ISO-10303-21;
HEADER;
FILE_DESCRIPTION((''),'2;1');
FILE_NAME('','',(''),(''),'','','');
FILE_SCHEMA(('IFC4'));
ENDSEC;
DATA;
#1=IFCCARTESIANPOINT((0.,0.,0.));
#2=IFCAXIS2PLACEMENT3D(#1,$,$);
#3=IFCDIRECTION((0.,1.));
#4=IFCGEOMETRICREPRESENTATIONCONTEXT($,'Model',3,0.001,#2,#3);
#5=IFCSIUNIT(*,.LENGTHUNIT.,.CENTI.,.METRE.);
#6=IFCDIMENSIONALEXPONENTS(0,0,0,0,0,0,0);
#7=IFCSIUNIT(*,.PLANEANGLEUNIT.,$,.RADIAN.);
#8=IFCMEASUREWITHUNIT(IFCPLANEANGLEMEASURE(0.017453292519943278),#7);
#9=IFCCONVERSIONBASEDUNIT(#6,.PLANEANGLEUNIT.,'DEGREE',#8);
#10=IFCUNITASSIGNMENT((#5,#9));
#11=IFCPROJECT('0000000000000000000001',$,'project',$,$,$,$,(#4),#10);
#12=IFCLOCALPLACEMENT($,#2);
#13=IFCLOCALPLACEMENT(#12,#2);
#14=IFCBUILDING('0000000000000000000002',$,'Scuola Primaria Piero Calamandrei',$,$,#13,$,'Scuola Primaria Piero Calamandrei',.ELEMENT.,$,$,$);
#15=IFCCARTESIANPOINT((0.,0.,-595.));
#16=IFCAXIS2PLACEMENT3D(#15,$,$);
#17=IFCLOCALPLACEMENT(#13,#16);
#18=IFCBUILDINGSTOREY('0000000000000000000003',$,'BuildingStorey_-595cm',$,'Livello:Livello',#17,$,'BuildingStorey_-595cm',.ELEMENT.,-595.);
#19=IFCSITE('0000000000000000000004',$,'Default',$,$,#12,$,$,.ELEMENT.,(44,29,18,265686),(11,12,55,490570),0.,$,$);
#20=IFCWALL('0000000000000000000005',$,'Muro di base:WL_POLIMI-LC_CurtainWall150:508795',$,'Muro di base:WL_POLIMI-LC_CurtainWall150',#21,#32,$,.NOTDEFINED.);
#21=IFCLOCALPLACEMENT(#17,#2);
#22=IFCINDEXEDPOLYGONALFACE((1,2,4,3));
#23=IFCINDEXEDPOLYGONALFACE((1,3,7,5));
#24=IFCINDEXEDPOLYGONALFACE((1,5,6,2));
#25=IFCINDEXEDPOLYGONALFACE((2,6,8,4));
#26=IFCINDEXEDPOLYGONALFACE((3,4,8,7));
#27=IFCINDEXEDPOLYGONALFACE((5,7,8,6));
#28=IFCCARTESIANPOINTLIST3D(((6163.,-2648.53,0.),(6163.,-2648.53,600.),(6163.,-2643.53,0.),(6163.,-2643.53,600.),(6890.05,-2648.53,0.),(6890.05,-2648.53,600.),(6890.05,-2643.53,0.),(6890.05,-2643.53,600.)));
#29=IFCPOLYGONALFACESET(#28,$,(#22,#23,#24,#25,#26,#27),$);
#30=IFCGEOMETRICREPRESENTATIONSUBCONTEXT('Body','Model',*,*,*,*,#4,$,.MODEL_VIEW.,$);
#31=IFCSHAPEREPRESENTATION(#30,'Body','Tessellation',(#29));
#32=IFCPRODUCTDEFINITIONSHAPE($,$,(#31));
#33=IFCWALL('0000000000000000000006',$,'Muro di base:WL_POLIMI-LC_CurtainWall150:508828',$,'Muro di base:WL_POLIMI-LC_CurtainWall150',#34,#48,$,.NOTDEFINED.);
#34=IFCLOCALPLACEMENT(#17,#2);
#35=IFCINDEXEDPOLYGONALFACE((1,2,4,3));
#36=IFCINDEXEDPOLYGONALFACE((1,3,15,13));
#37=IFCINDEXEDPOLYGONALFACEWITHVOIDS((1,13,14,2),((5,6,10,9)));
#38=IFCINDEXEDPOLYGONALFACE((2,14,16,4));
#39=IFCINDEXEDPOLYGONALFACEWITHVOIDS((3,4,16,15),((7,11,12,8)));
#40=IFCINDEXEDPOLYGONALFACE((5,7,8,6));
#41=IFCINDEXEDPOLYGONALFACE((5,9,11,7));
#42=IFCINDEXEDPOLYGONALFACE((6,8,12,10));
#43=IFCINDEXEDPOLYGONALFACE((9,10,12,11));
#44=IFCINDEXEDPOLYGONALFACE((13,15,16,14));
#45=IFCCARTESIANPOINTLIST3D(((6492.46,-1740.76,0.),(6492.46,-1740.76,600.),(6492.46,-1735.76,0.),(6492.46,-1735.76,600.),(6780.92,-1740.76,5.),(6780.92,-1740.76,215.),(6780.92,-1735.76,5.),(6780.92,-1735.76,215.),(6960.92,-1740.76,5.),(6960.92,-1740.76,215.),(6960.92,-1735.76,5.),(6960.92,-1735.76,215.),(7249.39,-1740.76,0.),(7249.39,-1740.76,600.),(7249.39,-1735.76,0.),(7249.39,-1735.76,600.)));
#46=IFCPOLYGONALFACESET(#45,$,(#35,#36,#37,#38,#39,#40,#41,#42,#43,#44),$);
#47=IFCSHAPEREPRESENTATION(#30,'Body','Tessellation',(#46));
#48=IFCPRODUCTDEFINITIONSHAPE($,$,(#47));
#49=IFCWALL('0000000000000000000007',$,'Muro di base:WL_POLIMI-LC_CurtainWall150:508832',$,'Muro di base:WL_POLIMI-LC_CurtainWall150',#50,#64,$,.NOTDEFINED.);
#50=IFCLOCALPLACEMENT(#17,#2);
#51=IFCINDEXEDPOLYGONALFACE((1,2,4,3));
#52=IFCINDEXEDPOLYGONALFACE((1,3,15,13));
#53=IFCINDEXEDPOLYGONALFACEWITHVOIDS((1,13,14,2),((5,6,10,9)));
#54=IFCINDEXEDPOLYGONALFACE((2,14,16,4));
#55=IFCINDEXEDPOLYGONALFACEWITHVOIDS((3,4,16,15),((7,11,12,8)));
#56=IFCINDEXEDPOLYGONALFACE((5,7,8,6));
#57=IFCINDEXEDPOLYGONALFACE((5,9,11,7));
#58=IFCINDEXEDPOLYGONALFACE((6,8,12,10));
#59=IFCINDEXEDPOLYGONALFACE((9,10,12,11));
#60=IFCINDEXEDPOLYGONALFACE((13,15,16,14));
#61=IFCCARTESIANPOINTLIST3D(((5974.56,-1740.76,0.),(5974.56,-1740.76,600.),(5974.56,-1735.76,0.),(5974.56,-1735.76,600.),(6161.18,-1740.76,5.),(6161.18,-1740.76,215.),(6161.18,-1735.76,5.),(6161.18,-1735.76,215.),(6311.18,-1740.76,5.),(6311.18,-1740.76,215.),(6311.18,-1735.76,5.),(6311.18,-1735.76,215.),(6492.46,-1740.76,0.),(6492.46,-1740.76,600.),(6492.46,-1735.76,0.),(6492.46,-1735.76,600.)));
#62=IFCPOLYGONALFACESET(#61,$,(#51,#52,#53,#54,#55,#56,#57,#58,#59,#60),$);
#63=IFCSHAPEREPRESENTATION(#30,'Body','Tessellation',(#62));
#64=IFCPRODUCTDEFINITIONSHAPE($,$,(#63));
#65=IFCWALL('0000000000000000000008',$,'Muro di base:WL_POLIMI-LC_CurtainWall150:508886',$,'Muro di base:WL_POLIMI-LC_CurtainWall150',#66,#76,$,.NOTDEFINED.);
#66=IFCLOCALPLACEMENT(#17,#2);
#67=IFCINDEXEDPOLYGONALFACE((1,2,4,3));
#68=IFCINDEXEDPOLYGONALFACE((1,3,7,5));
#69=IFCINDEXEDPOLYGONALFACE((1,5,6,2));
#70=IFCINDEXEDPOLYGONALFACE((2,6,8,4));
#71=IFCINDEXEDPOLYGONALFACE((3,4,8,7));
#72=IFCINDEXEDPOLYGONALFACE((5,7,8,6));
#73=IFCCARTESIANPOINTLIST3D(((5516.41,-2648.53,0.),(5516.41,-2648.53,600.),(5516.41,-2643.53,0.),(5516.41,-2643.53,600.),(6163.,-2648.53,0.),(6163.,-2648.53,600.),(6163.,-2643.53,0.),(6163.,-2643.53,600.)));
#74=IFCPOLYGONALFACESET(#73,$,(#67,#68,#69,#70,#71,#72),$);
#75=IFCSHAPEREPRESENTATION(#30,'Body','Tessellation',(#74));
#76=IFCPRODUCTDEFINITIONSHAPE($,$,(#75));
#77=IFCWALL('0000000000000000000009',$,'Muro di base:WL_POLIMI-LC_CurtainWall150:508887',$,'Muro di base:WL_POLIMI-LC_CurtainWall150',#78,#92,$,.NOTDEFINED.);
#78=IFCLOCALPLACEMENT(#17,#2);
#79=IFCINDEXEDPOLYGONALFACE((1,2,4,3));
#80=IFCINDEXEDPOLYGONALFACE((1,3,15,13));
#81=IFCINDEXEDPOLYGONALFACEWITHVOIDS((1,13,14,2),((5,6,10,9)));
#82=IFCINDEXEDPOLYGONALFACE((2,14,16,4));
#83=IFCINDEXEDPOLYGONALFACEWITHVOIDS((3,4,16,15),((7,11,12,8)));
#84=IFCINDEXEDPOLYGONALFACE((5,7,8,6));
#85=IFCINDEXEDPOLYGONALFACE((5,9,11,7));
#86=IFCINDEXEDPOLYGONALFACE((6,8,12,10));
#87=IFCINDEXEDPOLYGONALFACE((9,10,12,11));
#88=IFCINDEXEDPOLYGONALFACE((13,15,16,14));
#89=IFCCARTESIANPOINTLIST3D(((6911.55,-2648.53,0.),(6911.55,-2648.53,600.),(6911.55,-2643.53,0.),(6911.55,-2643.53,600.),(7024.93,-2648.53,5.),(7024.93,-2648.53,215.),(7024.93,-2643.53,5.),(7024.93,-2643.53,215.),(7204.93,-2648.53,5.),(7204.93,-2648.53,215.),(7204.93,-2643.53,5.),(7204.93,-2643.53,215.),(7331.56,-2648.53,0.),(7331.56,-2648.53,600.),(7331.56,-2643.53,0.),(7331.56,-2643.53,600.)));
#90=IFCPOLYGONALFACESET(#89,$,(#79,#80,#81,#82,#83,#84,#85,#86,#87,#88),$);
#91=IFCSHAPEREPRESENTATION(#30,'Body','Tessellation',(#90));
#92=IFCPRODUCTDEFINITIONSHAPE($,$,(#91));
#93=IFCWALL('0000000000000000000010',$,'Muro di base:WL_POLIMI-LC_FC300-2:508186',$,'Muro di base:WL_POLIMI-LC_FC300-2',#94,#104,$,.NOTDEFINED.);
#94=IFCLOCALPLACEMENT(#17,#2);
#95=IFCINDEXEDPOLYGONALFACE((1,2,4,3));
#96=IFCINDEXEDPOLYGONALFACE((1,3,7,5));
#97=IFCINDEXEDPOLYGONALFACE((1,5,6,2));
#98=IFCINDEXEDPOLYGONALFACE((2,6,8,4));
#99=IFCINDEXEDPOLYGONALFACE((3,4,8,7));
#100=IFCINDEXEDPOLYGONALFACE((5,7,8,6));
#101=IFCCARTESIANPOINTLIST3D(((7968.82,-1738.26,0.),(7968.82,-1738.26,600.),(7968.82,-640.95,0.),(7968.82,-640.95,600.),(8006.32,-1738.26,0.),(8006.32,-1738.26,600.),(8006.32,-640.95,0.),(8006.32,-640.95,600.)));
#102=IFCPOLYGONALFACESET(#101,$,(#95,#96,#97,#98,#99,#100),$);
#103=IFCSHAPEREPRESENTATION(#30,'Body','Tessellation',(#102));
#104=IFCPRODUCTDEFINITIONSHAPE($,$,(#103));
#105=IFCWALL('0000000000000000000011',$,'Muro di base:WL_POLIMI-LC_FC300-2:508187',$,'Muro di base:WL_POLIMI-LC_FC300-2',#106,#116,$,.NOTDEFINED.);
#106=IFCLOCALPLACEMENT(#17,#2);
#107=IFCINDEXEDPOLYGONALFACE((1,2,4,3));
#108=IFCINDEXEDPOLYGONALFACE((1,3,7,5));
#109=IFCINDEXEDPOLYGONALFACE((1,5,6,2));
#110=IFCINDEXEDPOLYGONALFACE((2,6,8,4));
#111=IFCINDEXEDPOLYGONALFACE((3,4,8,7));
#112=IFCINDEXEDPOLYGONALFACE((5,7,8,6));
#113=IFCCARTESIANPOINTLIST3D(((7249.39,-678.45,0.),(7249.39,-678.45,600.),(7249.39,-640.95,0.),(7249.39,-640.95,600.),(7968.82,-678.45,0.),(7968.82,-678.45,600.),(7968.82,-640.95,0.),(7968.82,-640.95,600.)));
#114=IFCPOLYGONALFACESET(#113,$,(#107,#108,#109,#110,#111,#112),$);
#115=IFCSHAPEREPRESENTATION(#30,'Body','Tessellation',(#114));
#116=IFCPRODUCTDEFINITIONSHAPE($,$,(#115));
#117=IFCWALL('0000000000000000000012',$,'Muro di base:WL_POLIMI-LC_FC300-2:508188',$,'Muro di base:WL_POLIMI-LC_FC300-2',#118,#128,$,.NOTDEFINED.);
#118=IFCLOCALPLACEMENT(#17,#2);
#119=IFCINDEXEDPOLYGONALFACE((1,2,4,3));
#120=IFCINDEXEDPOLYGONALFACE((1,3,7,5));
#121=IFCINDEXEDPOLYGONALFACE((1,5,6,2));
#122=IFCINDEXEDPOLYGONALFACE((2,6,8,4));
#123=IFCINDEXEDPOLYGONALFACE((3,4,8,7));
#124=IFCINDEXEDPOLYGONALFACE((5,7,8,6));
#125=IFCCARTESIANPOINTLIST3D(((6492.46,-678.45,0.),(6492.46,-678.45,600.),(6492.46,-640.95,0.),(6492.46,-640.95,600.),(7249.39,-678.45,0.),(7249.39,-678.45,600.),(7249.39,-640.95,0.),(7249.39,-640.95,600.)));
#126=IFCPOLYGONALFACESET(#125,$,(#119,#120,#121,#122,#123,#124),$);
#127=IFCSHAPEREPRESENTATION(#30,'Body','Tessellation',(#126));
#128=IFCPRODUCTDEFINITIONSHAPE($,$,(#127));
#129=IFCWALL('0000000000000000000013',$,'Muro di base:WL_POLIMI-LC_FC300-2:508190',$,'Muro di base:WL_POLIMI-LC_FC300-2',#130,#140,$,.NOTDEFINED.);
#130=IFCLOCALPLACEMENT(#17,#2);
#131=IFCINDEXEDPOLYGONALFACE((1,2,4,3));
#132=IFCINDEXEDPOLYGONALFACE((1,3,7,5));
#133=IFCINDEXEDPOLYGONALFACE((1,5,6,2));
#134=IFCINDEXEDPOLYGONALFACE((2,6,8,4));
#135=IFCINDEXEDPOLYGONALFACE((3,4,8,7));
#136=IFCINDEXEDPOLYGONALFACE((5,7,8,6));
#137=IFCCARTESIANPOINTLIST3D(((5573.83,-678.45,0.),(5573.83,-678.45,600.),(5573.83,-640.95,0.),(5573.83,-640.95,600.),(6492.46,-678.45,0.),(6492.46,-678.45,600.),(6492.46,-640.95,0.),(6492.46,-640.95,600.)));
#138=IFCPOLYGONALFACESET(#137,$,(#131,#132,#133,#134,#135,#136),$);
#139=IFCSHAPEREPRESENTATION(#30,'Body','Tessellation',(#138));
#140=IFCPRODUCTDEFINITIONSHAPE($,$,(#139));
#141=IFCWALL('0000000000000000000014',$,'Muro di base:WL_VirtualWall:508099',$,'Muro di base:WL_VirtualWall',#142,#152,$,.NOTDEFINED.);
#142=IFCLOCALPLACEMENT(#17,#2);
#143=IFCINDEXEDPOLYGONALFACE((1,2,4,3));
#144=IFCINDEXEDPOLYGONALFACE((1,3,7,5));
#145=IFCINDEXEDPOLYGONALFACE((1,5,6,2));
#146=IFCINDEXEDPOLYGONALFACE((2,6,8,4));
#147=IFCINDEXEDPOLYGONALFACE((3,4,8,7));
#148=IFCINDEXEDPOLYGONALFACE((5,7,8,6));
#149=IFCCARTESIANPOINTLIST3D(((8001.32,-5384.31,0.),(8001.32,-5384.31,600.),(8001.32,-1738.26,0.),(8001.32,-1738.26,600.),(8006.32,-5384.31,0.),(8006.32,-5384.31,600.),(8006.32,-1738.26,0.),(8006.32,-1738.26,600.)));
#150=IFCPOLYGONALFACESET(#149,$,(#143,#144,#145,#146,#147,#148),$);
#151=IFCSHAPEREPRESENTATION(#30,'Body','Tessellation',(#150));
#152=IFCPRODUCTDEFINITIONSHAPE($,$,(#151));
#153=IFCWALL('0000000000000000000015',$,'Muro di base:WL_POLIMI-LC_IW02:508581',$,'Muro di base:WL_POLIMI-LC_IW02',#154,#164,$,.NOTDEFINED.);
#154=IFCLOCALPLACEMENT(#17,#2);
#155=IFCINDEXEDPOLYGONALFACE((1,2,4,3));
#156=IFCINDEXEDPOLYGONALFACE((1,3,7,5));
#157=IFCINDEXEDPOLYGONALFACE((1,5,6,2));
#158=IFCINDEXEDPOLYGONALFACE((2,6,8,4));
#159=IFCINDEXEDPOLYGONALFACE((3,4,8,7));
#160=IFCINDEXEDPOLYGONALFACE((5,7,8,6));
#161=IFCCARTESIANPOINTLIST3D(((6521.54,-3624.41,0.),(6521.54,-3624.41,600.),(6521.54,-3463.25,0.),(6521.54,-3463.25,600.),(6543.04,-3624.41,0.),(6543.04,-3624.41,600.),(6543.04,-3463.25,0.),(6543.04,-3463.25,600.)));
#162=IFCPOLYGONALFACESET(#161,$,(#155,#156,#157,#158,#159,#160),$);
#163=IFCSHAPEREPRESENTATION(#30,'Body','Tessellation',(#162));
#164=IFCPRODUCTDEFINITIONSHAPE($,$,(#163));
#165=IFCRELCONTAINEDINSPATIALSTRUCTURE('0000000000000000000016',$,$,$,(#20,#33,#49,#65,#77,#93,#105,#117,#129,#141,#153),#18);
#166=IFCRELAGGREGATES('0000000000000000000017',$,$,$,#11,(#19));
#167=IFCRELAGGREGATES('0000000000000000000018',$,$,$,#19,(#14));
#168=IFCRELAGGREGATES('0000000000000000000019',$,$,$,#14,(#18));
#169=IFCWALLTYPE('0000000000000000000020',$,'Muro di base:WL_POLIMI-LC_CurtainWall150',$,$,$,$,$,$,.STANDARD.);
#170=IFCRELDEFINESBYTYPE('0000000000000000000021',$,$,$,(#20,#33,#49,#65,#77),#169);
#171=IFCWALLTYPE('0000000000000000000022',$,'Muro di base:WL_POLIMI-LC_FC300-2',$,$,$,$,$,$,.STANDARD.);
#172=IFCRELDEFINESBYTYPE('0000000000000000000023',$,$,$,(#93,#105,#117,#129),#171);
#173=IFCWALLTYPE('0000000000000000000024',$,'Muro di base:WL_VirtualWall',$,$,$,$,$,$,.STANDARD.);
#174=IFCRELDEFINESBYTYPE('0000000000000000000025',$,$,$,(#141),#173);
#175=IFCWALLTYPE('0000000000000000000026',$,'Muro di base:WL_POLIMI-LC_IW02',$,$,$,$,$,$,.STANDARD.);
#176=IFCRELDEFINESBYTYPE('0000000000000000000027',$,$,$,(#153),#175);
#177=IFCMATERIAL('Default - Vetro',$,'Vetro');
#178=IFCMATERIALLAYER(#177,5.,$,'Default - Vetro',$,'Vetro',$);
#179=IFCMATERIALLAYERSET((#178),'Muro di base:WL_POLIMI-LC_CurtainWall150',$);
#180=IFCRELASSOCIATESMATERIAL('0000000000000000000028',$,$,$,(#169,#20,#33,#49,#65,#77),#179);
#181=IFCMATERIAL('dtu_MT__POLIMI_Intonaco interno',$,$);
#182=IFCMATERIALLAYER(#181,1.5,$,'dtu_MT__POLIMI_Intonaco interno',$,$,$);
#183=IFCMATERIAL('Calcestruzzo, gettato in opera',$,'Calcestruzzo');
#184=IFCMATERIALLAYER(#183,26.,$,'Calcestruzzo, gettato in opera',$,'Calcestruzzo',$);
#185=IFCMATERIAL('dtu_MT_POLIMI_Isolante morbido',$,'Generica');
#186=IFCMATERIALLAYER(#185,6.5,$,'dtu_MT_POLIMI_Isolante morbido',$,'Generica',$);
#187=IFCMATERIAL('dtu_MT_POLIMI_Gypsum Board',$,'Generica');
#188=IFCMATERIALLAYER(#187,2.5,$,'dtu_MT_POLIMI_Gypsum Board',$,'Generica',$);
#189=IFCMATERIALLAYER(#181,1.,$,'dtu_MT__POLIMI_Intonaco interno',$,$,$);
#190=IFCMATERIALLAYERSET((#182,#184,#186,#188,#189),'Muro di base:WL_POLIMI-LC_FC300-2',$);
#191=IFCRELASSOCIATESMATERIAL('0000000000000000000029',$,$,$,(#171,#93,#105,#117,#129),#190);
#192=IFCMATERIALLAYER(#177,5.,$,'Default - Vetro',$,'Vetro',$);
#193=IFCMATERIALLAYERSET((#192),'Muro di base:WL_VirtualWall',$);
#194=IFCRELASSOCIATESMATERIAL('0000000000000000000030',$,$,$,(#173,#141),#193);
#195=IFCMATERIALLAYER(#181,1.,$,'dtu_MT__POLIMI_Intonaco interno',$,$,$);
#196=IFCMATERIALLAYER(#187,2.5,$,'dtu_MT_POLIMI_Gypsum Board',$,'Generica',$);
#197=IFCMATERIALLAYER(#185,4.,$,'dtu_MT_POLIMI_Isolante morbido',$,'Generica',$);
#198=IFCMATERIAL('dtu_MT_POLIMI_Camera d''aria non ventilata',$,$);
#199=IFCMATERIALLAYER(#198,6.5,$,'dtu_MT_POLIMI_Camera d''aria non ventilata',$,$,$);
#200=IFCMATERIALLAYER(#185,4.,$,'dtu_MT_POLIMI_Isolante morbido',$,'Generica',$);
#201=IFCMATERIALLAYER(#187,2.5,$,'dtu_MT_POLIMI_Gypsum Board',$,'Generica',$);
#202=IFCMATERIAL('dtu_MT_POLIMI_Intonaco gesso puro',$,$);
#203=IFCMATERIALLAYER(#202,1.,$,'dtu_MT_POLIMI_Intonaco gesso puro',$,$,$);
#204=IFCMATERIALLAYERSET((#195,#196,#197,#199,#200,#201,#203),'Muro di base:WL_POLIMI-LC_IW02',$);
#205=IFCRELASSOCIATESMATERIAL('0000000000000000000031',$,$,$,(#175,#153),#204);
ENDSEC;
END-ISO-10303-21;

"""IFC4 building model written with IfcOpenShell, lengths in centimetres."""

from ifc_helpers import new_model, entity, si_unit, converted_unit, direction, frame, frame_2d, origin, place, context, subcontext, project, spatial, rectangle, extrude, material, layer, layer_set, layer_usage, type_object, element, save


model = new_model("IFC4")

# Units and contexts
model_context = context("Model", 3, precision=0.001, world=origin(), true_north=direction((0.0, 1.0)))
body_context = subcontext(model_context, "Body", "Model", "MODEL_VIEW")
ifc_project = project(units=[si_unit("LENGTHUNIT", "METRE", prefix="CENTI"), converted_unit("PLANEANGLEUNIT", "DEGREE", entity("IfcPlaneAngleMeasure", 0.017453292519943278), si_unit("PLANEANGLEUNIT", "RADIAN"), dimensions=[0, 0, 0, 0, 0, 0, 0])], contexts=[model_context])

# Site, building, storey
site_placement = place(None, origin())
site = spatial("IfcSite", under=ifc_project, at=site_placement, Name="Default", CompositionType="ELEMENT", RefLatitude=(44, 29, 18, 265686), RefLongitude=(11, 12, 55, 490570), RefElevation=0.0)
building_placement = place(site_placement, origin())
building = spatial("IfcBuilding", under=site, at=building_placement, Name="Scuola Primaria Piero Calamandrei", LongName="Scuola Primaria Piero Calamandrei", CompositionType="ELEMENT")
storey_placement = place(building_placement, frame((0.0, 0.0, -595.0)))
storey = spatial("IfcBuildingStorey", under=building, at=storey_placement, Name="BuildingStorey_-595cm", ObjectType="Livello:Livello", LongName="BuildingStorey_-595cm", CompositionType="ELEMENT", Elevation=-595.0)

# Wall
ifc_material_1 = material(Name="Default - Vetro", Category="Vetro")
ifc_layer_1 = layer(ifc_material_1, 5.0, Name="Default - Vetro", Category="Vetro")
ifc_layer_set_1 = layer_set([ifc_layer_1], Name="Muro di base:WL_POLIMI-LC_CurtainWall150")
ifc_layer_usage_1 = layer_usage(ifc_layer_set_1, "AXIS2", "NEGATIVE", 2.5)
wall_type_1 = type_object("IfcWallType", Name="Muro di base:WL_POLIMI-LC_CurtainWall150", PredefinedType="STANDARD", material=ifc_layer_set_1)
wall_1_placement = place(storey_placement, frame((6163.0, -2646.03, 0.0)))
element("IfcWall", 1, at=wall_1_placement, inside=storey, type_object=wall_type_1, material=ifc_layer_usage_1, Name="Muro di base:WL_POLIMI-LC_CurtainWall150:508795", ObjectType="Muro di base:WL_POLIMI-LC_CurtainWall150", PredefinedType="NOTDEFINED", context=body_context, shape_type="SweptSolid", body=[
    extrude(rectangle(XDim=727.05, YDim=5.0, at=frame_2d((363.53, 0.0), x_axis=(-1.0, 0.0))), origin(), (0.0, 0.0, 1.0), 600.0),
])

# Walls, openings
ifc_layer_usage_2 = layer_usage(ifc_layer_set_1, "AXIS2", "NEGATIVE", 2.5)
wall_2_placement = place(storey_placement, frame((6492.46, -1738.26, 0.0)))
wall_2 = element("IfcWall", 2, at=wall_2_placement, inside=storey, type_object=wall_type_1, material=ifc_layer_usage_2, Name="Muro di base:WL_POLIMI-LC_CurtainWall150:508828", ObjectType="Muro di base:WL_POLIMI-LC_CurtainWall150", PredefinedType="NOTDEFINED", context=body_context, shape_type="SweptSolid", body=[
    extrude(rectangle(XDim=756.93, YDim=5.0, at=frame_2d((378.47, 0.0), x_axis=(-1.0, 0.0))), origin(), (0.0, 0.0, 1.0), 600.0),
])
opening_1_placement = place(wall_2_placement, frame((468.47, 2.5, 5.0)))
element("IfcOpeningElement", 3, at=opening_1_placement, cuts=wall_2, PredefinedType="OPENING", context=body_context, shape_type="SweptSolid", body=[
    extrude(rectangle(XDim=210.0, YDim=180.0, at=frame_2d((105.0, 90.0), x_axis=(-1.0, 0.0))), frame((0.0, 0.0, 0.0), z_axis=(0.0, -1.0, 0.0), x_axis=(0.0, 0.0, 1.0)), (0.0, 0.0, 1.0), 5.0),
])
ifc_layer_usage_3 = layer_usage(ifc_layer_set_1, "AXIS2", "NEGATIVE", 2.5)
wall_3_placement = place(storey_placement, frame((5974.56, -1738.26, 0.0)))
wall_3 = element("IfcWall", 4, at=wall_3_placement, inside=storey, type_object=wall_type_1, material=ifc_layer_usage_3, Name="Muro di base:WL_POLIMI-LC_CurtainWall150:508832", ObjectType="Muro di base:WL_POLIMI-LC_CurtainWall150", PredefinedType="NOTDEFINED", context=body_context, shape_type="SweptSolid", body=[
    extrude(rectangle(XDim=517.9, YDim=5.0, at=frame_2d((258.95, 0.0), x_axis=(-1.0, 0.0))), origin(), (0.0, 0.0, 1.0), 600.0),
])
opening_2_placement = place(wall_3_placement, frame((336.63, 2.5, 5.0)))
element("IfcOpeningElement", 5, at=opening_2_placement, cuts=wall_3, PredefinedType="OPENING", context=body_context, shape_type="SweptSolid", body=[
    extrude(rectangle(XDim=210.0, YDim=150.0, at=frame_2d((105.0, 75.0), x_axis=(-1.0, 0.0))), frame((0.0, 0.0, 0.0), z_axis=(0.0, -1.0, 0.0), x_axis=(0.0, 0.0, 1.0)), (0.0, 0.0, 1.0), 5.0),
])

# Wall
ifc_layer_usage_4 = layer_usage(ifc_layer_set_1, "AXIS2", "NEGATIVE", 2.5)
wall_4_placement = place(storey_placement, frame((6163.0, -2646.03, 0.0), z_axis=(0.0, 0.0, 1.0), x_axis=(-1.0, 0.0, 0.0)))
element("IfcWall", 6, at=wall_4_placement, inside=storey, type_object=wall_type_1, material=ifc_layer_usage_4, Name="Muro di base:WL_POLIMI-LC_CurtainWall150:508886", ObjectType="Muro di base:WL_POLIMI-LC_CurtainWall150", PredefinedType="NOTDEFINED", context=body_context, shape_type="SweptSolid", body=[
    extrude(rectangle(XDim=646.58, YDim=5.0, at=frame_2d((323.29, 0.0), x_axis=(-1.0, 0.0))), origin(), (0.0, 0.0, 1.0), 600.0),
])

# Wall, opening
ifc_layer_usage_5 = layer_usage(ifc_layer_set_1, "AXIS2", "NEGATIVE", 2.5)
wall_5_placement = place(storey_placement, frame((7331.56, -2646.03, 0.0), z_axis=(0.0, 0.0, 1.0), x_axis=(-1.0, 0.0, 0.0)))
wall_5 = element("IfcWall", 7, at=wall_5_placement, inside=storey, type_object=wall_type_1, material=ifc_layer_usage_5, Name="Muro di base:WL_POLIMI-LC_CurtainWall150:508887", ObjectType="Muro di base:WL_POLIMI-LC_CurtainWall150", PredefinedType="NOTDEFINED", context=body_context, shape_type="SweptSolid", body=[
    extrude(rectangle(XDim=420.01, YDim=5.0, at=frame_2d((210.01, 0.0), x_axis=(-1.0, 0.0))), origin(), (0.0, 0.0, 1.0), 600.0),
])
opening_3_placement = place(wall_5_placement, frame((126.63, -2.5, 5.0)))
element("IfcOpeningElement", 8, at=opening_3_placement, cuts=wall_5, PredefinedType="OPENING", context=body_context, shape_type="SweptSolid", body=[
    extrude(rectangle(XDim=210.0, YDim=180.0, at=frame_2d((105.0, 90.0), x_axis=(1.0, 0.0))), frame((0.0, 0.0, 0.0), z_axis=(0.0, 1.0, 0.0), x_axis=(0.0, 0.0, 1.0)), (0.0, 0.0, 1.0), 5.0),
])

# Walls
ifc_material_2 = material(Name="dtu_MT__POLIMI_Intonaco interno")
ifc_layer_2 = layer(ifc_material_2, 1.5, Name="dtu_MT__POLIMI_Intonaco interno")
ifc_material_3 = material(Name="Calcestruzzo, gettato in opera", Category="Calcestruzzo")
ifc_layer_3 = layer(ifc_material_3, 26.0, Name="Calcestruzzo, gettato in opera", Category="Calcestruzzo")
ifc_material_4 = material(Name="dtu_MT_POLIMI_Isolante morbido", Category="Generica")
ifc_layer_4 = layer(ifc_material_4, 6.5, Name="dtu_MT_POLIMI_Isolante morbido", Category="Generica")
ifc_material_5 = material(Name="dtu_MT_POLIMI_Gypsum Board", Category="Generica")
ifc_layer_5 = layer(ifc_material_5, 2.5, Name="dtu_MT_POLIMI_Gypsum Board", Category="Generica")
ifc_layer_6 = layer(ifc_material_2, 1.0, Name="dtu_MT__POLIMI_Intonaco interno")
ifc_layer_set_2 = layer_set([ifc_layer_2, ifc_layer_3, ifc_layer_4, ifc_layer_5, ifc_layer_6], Name="Muro di base:WL_POLIMI-LC_FC300-2")
ifc_layer_usage_6 = layer_usage(ifc_layer_set_2, "AXIS2", "NEGATIVE", 18.75)
wall_type_2 = type_object("IfcWallType", Name="Muro di base:WL_POLIMI-LC_FC300-2", PredefinedType="STANDARD", material=ifc_layer_set_2)
wall_6_placement = place(storey_placement, frame((7987.57, -640.95, 0.0), z_axis=(0.0, 0.0, 1.0), x_axis=(0.0, -1.0, 0.0)))
element("IfcWall", 9, at=wall_6_placement, inside=storey, type_object=wall_type_2, material=ifc_layer_usage_6, Name="Muro di base:WL_POLIMI-LC_FC300-2:508186", ObjectType="Muro di base:WL_POLIMI-LC_FC300-2", PredefinedType="NOTDEFINED", context=body_context, shape_type="SweptSolid", body=[
    extrude(rectangle(XDim=1097.31, YDim=37.5, at=frame_2d((548.66, 0.0), x_axis=(-1.0, 0.0))), origin(), (0.0, 0.0, 1.0), 600.0),
])
ifc_layer_usage_7 = layer_usage(ifc_layer_set_2, "AXIS2", "NEGATIVE", 18.75)
wall_7_placement = place(storey_placement, frame((7249.39, -659.7, 0.0)))
element("IfcWall", 10, at=wall_7_placement, inside=storey, type_object=wall_type_2, material=ifc_layer_usage_7, Name="Muro di base:WL_POLIMI-LC_FC300-2:508187", ObjectType="Muro di base:WL_POLIMI-LC_FC300-2", PredefinedType="NOTDEFINED", context=body_context, shape_type="SweptSolid", body=[
    extrude(rectangle(XDim=719.43, YDim=37.5, at=frame_2d((359.72, 0.0), x_axis=(-1.0, 0.0))), origin(), (0.0, 0.0, 1.0), 600.0),
])
ifc_layer_usage_8 = layer_usage(ifc_layer_set_2, "AXIS2", "NEGATIVE", 18.75)
wall_8_placement = place(storey_placement, frame((6492.46, -659.7, 0.0)))
element("IfcWall", 11, at=wall_8_placement, inside=storey, type_object=wall_type_2, material=ifc_layer_usage_8, Name="Muro di base:WL_POLIMI-LC_FC300-2:508188", ObjectType="Muro di base:WL_POLIMI-LC_FC300-2", PredefinedType="NOTDEFINED", context=body_context, shape_type="SweptSolid", body=[
    extrude(rectangle(XDim=756.93, YDim=37.5, at=frame_2d((378.47, 0.0), x_axis=(-1.0, 0.0))), origin(), (0.0, 0.0, 1.0), 600.0),
])
ifc_layer_usage_9 = layer_usage(ifc_layer_set_2, "AXIS2", "NEGATIVE", 18.75)
wall_9_placement = place(storey_placement, frame((5573.83, -659.7, 0.0)))
element("IfcWall", 12, at=wall_9_placement, inside=storey, type_object=wall_type_2, material=ifc_layer_usage_9, Name="Muro di base:WL_POLIMI-LC_FC300-2:508190", ObjectType="Muro di base:WL_POLIMI-LC_FC300-2", PredefinedType="NOTDEFINED", context=body_context, shape_type="SweptSolid", body=[
    extrude(rectangle(XDim=918.62, YDim=37.5, at=frame_2d((459.31, 0.0), x_axis=(-1.0, 0.0))), origin(), (0.0, 0.0, 1.0), 600.0),
])
ifc_layer_7 = layer(ifc_material_1, 5.0, Name="Default - Vetro", Category="Vetro")
ifc_layer_set_3 = layer_set([ifc_layer_7], Name="Muro di base:WL_VirtualWall")
ifc_layer_usage_10 = layer_usage(ifc_layer_set_3, "AXIS2", "NEGATIVE", 2.5)
wall_type_3 = type_object("IfcWallType", Name="Muro di base:WL_VirtualWall", PredefinedType="STANDARD", material=ifc_layer_set_3)
wall_10_placement = place(storey_placement, frame((8003.82, -1738.26, 0.0), z_axis=(0.0, 0.0, 1.0), x_axis=(0.0, -1.0, 0.0)))
element("IfcWall", 13, at=wall_10_placement, inside=storey, type_object=wall_type_3, material=ifc_layer_usage_10, Name="Muro di base:WL_VirtualWall:508099", ObjectType="Muro di base:WL_VirtualWall", PredefinedType="NOTDEFINED", context=body_context, shape_type="SweptSolid", body=[
    extrude(rectangle(XDim=3646.05, YDim=5.0, at=frame_2d((1823.03, 0.0), x_axis=(-1.0, 0.0))), origin(), (0.0, 0.0, 1.0), 600.0),
])
ifc_layer_8 = layer(ifc_material_2, 1.0, Name="dtu_MT__POLIMI_Intonaco interno")
ifc_layer_9 = layer(ifc_material_5, 2.5, Name="dtu_MT_POLIMI_Gypsum Board", Category="Generica")
ifc_layer_10 = layer(ifc_material_4, 4.0, Name="dtu_MT_POLIMI_Isolante morbido", Category="Generica")
ifc_material_6 = material(Name="dtu_MT_POLIMI_Camera d'aria non ventilata")
ifc_layer_11 = layer(ifc_material_6, 6.5, Name="dtu_MT_POLIMI_Camera d'aria non ventilata")
ifc_layer_12 = layer(ifc_material_4, 4.0, Name="dtu_MT_POLIMI_Isolante morbido", Category="Generica")
ifc_layer_13 = layer(ifc_material_5, 2.5, Name="dtu_MT_POLIMI_Gypsum Board", Category="Generica")
ifc_material_7 = material(Name="dtu_MT_POLIMI_Intonaco gesso puro")
ifc_layer_14 = layer(ifc_material_7, 1.0, Name="dtu_MT_POLIMI_Intonaco gesso puro")
ifc_layer_set_4 = layer_set([ifc_layer_8, ifc_layer_9, ifc_layer_10, ifc_layer_11, ifc_layer_12, ifc_layer_13, ifc_layer_14], Name="Muro di base:WL_POLIMI-LC_IW02")
ifc_layer_usage_11 = layer_usage(ifc_layer_set_4, "AXIS2", "NEGATIVE", 10.75)
wall_type_4 = type_object("IfcWallType", Name="Muro di base:WL_POLIMI-LC_IW02", PredefinedType="STANDARD", material=ifc_layer_set_4)
wall_11_placement = place(storey_placement, frame((6532.29, -3463.25, 0.0), z_axis=(0.0, 0.0, 1.0), x_axis=(0.0, -1.0, 0.0)))
element("IfcWall", 14, at=wall_11_placement, inside=storey, type_object=wall_type_4, material=ifc_layer_usage_11, Name="Muro di base:WL_POLIMI-LC_IW02:508581", ObjectType="Muro di base:WL_POLIMI-LC_IW02", PredefinedType="NOTDEFINED", context=body_context, shape_type="SweptSolid", body=[
    extrude(rectangle(XDim=161.16, YDim=21.5, at=frame_2d((80.58, 0.0), x_axis=(-1.0, 0.0))), origin(), (0.0, 0.0, 1.0), 600.0),
])

save(model, "model.ifc")
